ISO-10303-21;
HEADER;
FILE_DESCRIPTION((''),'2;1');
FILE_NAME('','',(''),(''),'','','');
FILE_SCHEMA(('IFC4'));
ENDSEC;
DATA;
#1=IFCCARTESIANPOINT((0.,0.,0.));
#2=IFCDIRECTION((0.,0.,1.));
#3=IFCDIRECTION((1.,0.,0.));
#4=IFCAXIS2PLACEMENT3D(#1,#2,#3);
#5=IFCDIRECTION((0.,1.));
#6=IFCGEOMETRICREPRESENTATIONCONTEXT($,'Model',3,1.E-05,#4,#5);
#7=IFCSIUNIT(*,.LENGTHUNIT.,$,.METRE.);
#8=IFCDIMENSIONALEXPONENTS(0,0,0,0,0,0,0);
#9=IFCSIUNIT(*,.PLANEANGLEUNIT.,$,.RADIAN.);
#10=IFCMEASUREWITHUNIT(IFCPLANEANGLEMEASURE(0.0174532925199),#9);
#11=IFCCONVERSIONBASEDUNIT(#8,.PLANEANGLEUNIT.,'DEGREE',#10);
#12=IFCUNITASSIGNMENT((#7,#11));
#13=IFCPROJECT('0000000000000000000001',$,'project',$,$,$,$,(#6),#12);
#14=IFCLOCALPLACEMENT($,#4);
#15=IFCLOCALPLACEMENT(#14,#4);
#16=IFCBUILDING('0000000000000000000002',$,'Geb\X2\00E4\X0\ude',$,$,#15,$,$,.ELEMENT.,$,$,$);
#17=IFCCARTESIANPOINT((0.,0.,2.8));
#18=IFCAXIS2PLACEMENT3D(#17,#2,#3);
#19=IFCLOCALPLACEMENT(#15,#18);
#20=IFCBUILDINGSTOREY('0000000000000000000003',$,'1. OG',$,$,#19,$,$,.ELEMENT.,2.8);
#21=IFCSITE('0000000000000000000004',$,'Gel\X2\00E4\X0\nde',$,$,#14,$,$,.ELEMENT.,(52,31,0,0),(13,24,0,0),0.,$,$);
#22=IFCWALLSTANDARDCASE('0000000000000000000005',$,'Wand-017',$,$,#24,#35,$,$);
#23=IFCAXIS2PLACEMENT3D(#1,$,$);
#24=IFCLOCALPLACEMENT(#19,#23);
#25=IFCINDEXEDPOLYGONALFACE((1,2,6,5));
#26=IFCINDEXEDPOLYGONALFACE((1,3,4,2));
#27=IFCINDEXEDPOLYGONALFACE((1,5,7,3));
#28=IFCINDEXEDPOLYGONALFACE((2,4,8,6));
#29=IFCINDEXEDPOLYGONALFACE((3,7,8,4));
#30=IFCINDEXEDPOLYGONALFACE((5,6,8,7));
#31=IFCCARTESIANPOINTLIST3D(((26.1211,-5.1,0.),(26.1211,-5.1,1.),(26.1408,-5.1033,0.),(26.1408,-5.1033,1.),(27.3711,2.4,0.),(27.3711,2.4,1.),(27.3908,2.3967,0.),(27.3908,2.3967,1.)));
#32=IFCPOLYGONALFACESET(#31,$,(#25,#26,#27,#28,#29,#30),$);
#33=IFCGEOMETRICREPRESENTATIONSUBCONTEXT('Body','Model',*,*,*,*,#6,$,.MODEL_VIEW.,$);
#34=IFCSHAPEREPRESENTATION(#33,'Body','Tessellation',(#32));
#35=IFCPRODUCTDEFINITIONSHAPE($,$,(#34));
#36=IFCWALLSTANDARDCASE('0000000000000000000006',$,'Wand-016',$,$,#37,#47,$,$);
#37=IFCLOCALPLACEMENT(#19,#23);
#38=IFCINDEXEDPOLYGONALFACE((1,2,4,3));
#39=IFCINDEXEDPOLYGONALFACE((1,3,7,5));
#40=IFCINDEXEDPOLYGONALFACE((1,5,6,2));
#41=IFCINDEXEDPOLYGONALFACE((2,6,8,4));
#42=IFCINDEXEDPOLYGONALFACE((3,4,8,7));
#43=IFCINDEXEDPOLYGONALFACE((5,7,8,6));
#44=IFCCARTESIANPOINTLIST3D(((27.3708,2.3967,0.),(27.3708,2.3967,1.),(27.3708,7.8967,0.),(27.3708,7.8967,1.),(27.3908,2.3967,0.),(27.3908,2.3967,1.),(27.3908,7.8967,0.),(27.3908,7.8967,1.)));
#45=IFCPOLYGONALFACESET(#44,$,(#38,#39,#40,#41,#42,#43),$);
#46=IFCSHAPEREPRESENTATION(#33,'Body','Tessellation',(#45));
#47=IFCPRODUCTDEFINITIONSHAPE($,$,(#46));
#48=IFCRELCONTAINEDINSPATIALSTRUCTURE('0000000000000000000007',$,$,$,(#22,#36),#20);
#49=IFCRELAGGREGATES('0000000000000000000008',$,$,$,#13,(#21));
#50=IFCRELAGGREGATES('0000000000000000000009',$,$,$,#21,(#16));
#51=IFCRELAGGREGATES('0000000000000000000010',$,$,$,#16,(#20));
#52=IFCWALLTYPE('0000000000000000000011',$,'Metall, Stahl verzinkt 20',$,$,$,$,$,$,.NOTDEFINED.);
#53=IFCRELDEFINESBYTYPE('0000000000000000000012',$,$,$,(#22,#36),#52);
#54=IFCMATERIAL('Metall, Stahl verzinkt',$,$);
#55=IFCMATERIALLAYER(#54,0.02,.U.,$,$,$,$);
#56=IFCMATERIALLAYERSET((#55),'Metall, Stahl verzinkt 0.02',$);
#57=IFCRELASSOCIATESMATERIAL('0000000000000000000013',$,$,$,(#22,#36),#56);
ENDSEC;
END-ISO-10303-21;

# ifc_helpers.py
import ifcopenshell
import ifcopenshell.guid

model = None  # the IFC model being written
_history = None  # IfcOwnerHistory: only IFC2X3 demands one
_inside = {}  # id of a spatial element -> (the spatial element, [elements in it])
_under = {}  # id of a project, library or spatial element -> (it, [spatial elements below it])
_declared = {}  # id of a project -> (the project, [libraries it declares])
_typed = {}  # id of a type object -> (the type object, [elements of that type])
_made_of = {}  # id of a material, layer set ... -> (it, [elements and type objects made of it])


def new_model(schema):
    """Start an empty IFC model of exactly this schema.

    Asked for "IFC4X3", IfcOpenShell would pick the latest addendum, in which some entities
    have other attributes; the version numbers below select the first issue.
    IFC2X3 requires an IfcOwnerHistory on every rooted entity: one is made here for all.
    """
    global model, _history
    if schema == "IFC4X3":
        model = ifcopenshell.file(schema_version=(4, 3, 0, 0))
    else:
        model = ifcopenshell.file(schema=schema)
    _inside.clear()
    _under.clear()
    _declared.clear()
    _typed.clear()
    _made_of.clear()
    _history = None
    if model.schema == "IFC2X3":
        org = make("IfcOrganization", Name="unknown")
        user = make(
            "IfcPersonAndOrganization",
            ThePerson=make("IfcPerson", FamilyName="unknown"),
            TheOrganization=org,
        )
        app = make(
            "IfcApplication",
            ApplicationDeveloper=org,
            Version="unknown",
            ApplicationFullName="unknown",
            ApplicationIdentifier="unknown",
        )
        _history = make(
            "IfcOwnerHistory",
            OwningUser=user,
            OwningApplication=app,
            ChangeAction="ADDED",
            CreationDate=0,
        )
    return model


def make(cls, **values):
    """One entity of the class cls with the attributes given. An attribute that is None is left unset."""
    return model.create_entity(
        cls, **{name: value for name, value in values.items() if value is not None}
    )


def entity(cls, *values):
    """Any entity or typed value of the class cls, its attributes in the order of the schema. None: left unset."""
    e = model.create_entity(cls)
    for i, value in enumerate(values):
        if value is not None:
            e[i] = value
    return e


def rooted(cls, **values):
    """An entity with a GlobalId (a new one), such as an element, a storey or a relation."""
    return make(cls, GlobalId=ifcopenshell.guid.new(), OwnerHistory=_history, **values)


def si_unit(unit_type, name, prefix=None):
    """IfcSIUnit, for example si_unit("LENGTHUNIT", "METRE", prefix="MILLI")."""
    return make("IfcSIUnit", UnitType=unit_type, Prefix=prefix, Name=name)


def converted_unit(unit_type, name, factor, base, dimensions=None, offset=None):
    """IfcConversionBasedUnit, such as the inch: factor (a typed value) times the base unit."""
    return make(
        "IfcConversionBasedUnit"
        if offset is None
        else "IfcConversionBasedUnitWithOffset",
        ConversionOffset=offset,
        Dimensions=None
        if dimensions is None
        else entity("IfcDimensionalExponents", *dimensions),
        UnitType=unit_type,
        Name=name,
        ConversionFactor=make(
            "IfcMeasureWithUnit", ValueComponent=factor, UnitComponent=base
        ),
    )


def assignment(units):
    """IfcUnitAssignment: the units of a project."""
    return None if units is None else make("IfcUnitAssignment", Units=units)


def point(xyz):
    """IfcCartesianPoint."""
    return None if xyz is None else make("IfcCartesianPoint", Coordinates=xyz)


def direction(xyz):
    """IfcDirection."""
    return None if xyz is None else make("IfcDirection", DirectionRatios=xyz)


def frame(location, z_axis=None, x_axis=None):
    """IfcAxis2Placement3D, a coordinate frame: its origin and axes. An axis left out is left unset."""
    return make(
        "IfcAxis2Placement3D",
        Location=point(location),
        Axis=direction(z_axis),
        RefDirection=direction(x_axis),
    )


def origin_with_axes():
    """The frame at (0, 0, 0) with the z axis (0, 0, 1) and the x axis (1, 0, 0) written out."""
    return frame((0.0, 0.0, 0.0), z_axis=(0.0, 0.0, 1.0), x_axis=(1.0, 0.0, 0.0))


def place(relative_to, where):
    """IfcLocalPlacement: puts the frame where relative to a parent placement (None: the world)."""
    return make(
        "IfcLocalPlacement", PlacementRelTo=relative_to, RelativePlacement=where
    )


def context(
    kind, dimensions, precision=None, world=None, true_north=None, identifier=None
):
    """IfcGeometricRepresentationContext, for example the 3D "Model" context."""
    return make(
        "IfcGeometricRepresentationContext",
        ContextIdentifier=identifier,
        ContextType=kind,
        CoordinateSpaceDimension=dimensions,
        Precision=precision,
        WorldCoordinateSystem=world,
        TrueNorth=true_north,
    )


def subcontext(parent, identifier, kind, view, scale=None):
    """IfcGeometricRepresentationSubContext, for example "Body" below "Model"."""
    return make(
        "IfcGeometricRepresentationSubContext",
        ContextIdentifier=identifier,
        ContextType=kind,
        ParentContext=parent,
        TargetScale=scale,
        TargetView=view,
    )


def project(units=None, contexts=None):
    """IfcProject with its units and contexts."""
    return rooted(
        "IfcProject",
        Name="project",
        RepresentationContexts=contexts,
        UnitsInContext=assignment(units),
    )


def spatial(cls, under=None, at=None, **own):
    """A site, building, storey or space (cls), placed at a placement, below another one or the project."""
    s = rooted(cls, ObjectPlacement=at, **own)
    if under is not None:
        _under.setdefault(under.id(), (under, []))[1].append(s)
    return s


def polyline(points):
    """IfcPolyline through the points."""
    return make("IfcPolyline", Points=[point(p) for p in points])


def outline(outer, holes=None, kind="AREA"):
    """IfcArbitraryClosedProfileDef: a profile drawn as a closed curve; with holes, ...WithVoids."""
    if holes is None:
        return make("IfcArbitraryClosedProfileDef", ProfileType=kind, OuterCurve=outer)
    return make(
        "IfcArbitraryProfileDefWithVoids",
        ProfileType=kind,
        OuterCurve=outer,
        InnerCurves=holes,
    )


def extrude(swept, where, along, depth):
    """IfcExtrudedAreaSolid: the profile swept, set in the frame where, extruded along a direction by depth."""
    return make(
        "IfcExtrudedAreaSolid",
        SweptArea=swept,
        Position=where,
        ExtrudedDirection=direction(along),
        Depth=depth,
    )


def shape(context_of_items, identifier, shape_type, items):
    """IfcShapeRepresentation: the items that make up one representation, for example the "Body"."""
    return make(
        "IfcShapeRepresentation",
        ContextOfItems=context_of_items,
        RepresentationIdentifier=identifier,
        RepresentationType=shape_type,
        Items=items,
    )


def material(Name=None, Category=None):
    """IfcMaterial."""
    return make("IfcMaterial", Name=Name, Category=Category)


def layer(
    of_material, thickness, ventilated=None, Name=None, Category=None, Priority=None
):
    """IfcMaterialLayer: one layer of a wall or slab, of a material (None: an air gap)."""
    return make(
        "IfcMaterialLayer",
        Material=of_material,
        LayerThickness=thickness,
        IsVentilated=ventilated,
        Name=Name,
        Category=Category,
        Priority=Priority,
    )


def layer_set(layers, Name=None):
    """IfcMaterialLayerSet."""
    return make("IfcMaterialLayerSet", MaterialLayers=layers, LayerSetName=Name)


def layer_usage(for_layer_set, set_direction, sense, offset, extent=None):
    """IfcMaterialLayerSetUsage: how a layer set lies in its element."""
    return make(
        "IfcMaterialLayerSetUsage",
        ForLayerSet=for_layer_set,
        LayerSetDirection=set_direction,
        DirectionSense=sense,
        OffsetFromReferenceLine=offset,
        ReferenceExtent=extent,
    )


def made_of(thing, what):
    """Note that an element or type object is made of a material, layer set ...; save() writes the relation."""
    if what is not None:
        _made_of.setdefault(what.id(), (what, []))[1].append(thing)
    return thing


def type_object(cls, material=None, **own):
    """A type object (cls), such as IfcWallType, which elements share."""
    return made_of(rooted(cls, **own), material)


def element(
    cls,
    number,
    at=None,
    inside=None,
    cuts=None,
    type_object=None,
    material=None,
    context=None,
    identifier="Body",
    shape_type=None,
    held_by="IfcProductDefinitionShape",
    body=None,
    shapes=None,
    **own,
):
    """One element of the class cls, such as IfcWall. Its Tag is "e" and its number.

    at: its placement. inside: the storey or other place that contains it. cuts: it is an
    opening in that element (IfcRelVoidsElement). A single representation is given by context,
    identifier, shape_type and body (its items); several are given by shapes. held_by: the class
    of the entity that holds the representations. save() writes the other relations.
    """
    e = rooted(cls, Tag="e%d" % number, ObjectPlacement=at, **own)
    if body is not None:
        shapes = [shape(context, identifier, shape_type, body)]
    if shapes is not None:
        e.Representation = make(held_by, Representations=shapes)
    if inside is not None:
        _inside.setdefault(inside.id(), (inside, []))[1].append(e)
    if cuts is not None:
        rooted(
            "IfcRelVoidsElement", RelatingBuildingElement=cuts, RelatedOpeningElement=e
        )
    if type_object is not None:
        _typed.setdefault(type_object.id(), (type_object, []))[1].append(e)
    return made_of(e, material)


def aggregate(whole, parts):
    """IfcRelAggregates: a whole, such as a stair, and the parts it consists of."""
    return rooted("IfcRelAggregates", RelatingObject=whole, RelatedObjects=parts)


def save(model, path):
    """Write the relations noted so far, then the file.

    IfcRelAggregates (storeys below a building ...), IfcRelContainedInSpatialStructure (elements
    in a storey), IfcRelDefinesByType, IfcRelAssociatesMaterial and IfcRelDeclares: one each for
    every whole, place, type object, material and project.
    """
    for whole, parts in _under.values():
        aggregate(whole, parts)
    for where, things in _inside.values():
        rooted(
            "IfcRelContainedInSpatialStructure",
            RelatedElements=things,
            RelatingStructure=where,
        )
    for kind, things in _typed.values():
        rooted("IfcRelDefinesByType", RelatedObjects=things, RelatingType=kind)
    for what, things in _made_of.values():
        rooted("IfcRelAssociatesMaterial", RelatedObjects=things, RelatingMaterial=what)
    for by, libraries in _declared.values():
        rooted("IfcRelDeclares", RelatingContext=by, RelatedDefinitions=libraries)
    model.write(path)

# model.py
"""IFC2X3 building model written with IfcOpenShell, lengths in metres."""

from ifc_helpers import new_model, entity, si_unit, converted_unit, direction, frame, origin_with_axes, place, context, subcontext, project, spatial, polyline, outline, extrude, material, layer, layer_set, layer_usage, type_object, element, save


model = new_model("IFC2X3")

# Units and contexts
model_context = context("Model", 3, precision=1e-05, world=origin_with_axes(), true_north=direction((0.0, 1.0)))
body_context = subcontext(model_context, "Body", "Model", "MODEL_VIEW")
ifc_project = project(units=[si_unit("LENGTHUNIT", "METRE"), converted_unit("PLANEANGLEUNIT", "DEGREE", entity("IfcPlaneAngleMeasure", 0.0174532925199), si_unit("PLANEANGLEUNIT", "RADIAN"), dimensions=[0, 0, 0, 0, 0, 0, 0])], contexts=[model_context])

# Site, building, storey
site_placement = place(None, origin_with_axes())
site = spatial("IfcSite", under=ifc_project, at=site_placement, Name="Gelände", CompositionType="ELEMENT", RefLatitude=(52, 31, 0, 0), RefLongitude=(13, 24, 0, 0), RefElevation=0.0)
building_placement = place(site_placement, origin_with_axes())
building = spatial("IfcBuilding", under=site, at=building_placement, Name="Gebäude", CompositionType="ELEMENT")
storey_placement = place(building_placement, frame((0.0, 0.0, 2.8), z_axis=(0.0, 0.0, 1.0), x_axis=(1.0, 0.0, 0.0)))
storey = spatial("IfcBuildingStorey", under=building, at=storey_placement, Name="1. OG", CompositionType="ELEMENT", Elevation=2.8)

# Walls
ifc_material_1 = material(Name="Metall, Stahl verzinkt")
ifc_layer_1 = layer(ifc_material_1, 0.02, ventilated="UNKNOWN")
ifc_layer_set_1 = layer_set([ifc_layer_1], Name="Metall, Stahl verzinkt 0.02")
wall_type_1 = type_object("IfcWallType", Name="Metall, Stahl verzinkt 20", PredefinedType="NOTDEFINED")
ifc_layer_usage_1 = layer_usage(ifc_layer_set_1, "AXIS2", "NEGATIVE", 0.0)
wall_1_placement = place(storey_placement, frame((27.3908, 2.3967, 0.0), z_axis=(0.0, 0.0, 1.0), x_axis=(-0.164399, -0.986394, 0.0)))
element("IfcWallStandardCase", 1, at=wall_1_placement, inside=storey, type_object=wall_type_1, material=ifc_layer_usage_1, Name="Wand-017", context=body_context, shape_type="SweptSolid", body=[
    extrude(outline(polyline([(0.0, -0.02), (7.6035, -0.02), (7.6035, 0.0), (0.0, 0.0), (0.0, -0.02)])), origin_with_axes(), (0.0, 0.0, 1.0), 1.0),
])
ifc_layer_usage_2 = layer_usage(ifc_layer_set_1, "AXIS2", "NEGATIVE", 0.0)
wall_2_placement = place(storey_placement, frame((27.3908, 7.8967, 0.0), z_axis=(0.0, 0.0, 1.0), x_axis=(0.0, -1.0, 0.0)))
element("IfcWallStandardCase", 2, at=wall_2_placement, inside=storey, type_object=wall_type_1, material=ifc_layer_usage_2, Name="Wand-016", context=body_context, shape_type="SweptSolid", body=[
    extrude(outline(polyline([(0.0, -0.02), (5.5, -0.02), (5.5, 0.0), (0.0, 0.0), (0.0, -0.02)])), origin_with_axes(), (0.0, 0.0, 1.0), 1.0),
])

save(model, "model.ifc")
